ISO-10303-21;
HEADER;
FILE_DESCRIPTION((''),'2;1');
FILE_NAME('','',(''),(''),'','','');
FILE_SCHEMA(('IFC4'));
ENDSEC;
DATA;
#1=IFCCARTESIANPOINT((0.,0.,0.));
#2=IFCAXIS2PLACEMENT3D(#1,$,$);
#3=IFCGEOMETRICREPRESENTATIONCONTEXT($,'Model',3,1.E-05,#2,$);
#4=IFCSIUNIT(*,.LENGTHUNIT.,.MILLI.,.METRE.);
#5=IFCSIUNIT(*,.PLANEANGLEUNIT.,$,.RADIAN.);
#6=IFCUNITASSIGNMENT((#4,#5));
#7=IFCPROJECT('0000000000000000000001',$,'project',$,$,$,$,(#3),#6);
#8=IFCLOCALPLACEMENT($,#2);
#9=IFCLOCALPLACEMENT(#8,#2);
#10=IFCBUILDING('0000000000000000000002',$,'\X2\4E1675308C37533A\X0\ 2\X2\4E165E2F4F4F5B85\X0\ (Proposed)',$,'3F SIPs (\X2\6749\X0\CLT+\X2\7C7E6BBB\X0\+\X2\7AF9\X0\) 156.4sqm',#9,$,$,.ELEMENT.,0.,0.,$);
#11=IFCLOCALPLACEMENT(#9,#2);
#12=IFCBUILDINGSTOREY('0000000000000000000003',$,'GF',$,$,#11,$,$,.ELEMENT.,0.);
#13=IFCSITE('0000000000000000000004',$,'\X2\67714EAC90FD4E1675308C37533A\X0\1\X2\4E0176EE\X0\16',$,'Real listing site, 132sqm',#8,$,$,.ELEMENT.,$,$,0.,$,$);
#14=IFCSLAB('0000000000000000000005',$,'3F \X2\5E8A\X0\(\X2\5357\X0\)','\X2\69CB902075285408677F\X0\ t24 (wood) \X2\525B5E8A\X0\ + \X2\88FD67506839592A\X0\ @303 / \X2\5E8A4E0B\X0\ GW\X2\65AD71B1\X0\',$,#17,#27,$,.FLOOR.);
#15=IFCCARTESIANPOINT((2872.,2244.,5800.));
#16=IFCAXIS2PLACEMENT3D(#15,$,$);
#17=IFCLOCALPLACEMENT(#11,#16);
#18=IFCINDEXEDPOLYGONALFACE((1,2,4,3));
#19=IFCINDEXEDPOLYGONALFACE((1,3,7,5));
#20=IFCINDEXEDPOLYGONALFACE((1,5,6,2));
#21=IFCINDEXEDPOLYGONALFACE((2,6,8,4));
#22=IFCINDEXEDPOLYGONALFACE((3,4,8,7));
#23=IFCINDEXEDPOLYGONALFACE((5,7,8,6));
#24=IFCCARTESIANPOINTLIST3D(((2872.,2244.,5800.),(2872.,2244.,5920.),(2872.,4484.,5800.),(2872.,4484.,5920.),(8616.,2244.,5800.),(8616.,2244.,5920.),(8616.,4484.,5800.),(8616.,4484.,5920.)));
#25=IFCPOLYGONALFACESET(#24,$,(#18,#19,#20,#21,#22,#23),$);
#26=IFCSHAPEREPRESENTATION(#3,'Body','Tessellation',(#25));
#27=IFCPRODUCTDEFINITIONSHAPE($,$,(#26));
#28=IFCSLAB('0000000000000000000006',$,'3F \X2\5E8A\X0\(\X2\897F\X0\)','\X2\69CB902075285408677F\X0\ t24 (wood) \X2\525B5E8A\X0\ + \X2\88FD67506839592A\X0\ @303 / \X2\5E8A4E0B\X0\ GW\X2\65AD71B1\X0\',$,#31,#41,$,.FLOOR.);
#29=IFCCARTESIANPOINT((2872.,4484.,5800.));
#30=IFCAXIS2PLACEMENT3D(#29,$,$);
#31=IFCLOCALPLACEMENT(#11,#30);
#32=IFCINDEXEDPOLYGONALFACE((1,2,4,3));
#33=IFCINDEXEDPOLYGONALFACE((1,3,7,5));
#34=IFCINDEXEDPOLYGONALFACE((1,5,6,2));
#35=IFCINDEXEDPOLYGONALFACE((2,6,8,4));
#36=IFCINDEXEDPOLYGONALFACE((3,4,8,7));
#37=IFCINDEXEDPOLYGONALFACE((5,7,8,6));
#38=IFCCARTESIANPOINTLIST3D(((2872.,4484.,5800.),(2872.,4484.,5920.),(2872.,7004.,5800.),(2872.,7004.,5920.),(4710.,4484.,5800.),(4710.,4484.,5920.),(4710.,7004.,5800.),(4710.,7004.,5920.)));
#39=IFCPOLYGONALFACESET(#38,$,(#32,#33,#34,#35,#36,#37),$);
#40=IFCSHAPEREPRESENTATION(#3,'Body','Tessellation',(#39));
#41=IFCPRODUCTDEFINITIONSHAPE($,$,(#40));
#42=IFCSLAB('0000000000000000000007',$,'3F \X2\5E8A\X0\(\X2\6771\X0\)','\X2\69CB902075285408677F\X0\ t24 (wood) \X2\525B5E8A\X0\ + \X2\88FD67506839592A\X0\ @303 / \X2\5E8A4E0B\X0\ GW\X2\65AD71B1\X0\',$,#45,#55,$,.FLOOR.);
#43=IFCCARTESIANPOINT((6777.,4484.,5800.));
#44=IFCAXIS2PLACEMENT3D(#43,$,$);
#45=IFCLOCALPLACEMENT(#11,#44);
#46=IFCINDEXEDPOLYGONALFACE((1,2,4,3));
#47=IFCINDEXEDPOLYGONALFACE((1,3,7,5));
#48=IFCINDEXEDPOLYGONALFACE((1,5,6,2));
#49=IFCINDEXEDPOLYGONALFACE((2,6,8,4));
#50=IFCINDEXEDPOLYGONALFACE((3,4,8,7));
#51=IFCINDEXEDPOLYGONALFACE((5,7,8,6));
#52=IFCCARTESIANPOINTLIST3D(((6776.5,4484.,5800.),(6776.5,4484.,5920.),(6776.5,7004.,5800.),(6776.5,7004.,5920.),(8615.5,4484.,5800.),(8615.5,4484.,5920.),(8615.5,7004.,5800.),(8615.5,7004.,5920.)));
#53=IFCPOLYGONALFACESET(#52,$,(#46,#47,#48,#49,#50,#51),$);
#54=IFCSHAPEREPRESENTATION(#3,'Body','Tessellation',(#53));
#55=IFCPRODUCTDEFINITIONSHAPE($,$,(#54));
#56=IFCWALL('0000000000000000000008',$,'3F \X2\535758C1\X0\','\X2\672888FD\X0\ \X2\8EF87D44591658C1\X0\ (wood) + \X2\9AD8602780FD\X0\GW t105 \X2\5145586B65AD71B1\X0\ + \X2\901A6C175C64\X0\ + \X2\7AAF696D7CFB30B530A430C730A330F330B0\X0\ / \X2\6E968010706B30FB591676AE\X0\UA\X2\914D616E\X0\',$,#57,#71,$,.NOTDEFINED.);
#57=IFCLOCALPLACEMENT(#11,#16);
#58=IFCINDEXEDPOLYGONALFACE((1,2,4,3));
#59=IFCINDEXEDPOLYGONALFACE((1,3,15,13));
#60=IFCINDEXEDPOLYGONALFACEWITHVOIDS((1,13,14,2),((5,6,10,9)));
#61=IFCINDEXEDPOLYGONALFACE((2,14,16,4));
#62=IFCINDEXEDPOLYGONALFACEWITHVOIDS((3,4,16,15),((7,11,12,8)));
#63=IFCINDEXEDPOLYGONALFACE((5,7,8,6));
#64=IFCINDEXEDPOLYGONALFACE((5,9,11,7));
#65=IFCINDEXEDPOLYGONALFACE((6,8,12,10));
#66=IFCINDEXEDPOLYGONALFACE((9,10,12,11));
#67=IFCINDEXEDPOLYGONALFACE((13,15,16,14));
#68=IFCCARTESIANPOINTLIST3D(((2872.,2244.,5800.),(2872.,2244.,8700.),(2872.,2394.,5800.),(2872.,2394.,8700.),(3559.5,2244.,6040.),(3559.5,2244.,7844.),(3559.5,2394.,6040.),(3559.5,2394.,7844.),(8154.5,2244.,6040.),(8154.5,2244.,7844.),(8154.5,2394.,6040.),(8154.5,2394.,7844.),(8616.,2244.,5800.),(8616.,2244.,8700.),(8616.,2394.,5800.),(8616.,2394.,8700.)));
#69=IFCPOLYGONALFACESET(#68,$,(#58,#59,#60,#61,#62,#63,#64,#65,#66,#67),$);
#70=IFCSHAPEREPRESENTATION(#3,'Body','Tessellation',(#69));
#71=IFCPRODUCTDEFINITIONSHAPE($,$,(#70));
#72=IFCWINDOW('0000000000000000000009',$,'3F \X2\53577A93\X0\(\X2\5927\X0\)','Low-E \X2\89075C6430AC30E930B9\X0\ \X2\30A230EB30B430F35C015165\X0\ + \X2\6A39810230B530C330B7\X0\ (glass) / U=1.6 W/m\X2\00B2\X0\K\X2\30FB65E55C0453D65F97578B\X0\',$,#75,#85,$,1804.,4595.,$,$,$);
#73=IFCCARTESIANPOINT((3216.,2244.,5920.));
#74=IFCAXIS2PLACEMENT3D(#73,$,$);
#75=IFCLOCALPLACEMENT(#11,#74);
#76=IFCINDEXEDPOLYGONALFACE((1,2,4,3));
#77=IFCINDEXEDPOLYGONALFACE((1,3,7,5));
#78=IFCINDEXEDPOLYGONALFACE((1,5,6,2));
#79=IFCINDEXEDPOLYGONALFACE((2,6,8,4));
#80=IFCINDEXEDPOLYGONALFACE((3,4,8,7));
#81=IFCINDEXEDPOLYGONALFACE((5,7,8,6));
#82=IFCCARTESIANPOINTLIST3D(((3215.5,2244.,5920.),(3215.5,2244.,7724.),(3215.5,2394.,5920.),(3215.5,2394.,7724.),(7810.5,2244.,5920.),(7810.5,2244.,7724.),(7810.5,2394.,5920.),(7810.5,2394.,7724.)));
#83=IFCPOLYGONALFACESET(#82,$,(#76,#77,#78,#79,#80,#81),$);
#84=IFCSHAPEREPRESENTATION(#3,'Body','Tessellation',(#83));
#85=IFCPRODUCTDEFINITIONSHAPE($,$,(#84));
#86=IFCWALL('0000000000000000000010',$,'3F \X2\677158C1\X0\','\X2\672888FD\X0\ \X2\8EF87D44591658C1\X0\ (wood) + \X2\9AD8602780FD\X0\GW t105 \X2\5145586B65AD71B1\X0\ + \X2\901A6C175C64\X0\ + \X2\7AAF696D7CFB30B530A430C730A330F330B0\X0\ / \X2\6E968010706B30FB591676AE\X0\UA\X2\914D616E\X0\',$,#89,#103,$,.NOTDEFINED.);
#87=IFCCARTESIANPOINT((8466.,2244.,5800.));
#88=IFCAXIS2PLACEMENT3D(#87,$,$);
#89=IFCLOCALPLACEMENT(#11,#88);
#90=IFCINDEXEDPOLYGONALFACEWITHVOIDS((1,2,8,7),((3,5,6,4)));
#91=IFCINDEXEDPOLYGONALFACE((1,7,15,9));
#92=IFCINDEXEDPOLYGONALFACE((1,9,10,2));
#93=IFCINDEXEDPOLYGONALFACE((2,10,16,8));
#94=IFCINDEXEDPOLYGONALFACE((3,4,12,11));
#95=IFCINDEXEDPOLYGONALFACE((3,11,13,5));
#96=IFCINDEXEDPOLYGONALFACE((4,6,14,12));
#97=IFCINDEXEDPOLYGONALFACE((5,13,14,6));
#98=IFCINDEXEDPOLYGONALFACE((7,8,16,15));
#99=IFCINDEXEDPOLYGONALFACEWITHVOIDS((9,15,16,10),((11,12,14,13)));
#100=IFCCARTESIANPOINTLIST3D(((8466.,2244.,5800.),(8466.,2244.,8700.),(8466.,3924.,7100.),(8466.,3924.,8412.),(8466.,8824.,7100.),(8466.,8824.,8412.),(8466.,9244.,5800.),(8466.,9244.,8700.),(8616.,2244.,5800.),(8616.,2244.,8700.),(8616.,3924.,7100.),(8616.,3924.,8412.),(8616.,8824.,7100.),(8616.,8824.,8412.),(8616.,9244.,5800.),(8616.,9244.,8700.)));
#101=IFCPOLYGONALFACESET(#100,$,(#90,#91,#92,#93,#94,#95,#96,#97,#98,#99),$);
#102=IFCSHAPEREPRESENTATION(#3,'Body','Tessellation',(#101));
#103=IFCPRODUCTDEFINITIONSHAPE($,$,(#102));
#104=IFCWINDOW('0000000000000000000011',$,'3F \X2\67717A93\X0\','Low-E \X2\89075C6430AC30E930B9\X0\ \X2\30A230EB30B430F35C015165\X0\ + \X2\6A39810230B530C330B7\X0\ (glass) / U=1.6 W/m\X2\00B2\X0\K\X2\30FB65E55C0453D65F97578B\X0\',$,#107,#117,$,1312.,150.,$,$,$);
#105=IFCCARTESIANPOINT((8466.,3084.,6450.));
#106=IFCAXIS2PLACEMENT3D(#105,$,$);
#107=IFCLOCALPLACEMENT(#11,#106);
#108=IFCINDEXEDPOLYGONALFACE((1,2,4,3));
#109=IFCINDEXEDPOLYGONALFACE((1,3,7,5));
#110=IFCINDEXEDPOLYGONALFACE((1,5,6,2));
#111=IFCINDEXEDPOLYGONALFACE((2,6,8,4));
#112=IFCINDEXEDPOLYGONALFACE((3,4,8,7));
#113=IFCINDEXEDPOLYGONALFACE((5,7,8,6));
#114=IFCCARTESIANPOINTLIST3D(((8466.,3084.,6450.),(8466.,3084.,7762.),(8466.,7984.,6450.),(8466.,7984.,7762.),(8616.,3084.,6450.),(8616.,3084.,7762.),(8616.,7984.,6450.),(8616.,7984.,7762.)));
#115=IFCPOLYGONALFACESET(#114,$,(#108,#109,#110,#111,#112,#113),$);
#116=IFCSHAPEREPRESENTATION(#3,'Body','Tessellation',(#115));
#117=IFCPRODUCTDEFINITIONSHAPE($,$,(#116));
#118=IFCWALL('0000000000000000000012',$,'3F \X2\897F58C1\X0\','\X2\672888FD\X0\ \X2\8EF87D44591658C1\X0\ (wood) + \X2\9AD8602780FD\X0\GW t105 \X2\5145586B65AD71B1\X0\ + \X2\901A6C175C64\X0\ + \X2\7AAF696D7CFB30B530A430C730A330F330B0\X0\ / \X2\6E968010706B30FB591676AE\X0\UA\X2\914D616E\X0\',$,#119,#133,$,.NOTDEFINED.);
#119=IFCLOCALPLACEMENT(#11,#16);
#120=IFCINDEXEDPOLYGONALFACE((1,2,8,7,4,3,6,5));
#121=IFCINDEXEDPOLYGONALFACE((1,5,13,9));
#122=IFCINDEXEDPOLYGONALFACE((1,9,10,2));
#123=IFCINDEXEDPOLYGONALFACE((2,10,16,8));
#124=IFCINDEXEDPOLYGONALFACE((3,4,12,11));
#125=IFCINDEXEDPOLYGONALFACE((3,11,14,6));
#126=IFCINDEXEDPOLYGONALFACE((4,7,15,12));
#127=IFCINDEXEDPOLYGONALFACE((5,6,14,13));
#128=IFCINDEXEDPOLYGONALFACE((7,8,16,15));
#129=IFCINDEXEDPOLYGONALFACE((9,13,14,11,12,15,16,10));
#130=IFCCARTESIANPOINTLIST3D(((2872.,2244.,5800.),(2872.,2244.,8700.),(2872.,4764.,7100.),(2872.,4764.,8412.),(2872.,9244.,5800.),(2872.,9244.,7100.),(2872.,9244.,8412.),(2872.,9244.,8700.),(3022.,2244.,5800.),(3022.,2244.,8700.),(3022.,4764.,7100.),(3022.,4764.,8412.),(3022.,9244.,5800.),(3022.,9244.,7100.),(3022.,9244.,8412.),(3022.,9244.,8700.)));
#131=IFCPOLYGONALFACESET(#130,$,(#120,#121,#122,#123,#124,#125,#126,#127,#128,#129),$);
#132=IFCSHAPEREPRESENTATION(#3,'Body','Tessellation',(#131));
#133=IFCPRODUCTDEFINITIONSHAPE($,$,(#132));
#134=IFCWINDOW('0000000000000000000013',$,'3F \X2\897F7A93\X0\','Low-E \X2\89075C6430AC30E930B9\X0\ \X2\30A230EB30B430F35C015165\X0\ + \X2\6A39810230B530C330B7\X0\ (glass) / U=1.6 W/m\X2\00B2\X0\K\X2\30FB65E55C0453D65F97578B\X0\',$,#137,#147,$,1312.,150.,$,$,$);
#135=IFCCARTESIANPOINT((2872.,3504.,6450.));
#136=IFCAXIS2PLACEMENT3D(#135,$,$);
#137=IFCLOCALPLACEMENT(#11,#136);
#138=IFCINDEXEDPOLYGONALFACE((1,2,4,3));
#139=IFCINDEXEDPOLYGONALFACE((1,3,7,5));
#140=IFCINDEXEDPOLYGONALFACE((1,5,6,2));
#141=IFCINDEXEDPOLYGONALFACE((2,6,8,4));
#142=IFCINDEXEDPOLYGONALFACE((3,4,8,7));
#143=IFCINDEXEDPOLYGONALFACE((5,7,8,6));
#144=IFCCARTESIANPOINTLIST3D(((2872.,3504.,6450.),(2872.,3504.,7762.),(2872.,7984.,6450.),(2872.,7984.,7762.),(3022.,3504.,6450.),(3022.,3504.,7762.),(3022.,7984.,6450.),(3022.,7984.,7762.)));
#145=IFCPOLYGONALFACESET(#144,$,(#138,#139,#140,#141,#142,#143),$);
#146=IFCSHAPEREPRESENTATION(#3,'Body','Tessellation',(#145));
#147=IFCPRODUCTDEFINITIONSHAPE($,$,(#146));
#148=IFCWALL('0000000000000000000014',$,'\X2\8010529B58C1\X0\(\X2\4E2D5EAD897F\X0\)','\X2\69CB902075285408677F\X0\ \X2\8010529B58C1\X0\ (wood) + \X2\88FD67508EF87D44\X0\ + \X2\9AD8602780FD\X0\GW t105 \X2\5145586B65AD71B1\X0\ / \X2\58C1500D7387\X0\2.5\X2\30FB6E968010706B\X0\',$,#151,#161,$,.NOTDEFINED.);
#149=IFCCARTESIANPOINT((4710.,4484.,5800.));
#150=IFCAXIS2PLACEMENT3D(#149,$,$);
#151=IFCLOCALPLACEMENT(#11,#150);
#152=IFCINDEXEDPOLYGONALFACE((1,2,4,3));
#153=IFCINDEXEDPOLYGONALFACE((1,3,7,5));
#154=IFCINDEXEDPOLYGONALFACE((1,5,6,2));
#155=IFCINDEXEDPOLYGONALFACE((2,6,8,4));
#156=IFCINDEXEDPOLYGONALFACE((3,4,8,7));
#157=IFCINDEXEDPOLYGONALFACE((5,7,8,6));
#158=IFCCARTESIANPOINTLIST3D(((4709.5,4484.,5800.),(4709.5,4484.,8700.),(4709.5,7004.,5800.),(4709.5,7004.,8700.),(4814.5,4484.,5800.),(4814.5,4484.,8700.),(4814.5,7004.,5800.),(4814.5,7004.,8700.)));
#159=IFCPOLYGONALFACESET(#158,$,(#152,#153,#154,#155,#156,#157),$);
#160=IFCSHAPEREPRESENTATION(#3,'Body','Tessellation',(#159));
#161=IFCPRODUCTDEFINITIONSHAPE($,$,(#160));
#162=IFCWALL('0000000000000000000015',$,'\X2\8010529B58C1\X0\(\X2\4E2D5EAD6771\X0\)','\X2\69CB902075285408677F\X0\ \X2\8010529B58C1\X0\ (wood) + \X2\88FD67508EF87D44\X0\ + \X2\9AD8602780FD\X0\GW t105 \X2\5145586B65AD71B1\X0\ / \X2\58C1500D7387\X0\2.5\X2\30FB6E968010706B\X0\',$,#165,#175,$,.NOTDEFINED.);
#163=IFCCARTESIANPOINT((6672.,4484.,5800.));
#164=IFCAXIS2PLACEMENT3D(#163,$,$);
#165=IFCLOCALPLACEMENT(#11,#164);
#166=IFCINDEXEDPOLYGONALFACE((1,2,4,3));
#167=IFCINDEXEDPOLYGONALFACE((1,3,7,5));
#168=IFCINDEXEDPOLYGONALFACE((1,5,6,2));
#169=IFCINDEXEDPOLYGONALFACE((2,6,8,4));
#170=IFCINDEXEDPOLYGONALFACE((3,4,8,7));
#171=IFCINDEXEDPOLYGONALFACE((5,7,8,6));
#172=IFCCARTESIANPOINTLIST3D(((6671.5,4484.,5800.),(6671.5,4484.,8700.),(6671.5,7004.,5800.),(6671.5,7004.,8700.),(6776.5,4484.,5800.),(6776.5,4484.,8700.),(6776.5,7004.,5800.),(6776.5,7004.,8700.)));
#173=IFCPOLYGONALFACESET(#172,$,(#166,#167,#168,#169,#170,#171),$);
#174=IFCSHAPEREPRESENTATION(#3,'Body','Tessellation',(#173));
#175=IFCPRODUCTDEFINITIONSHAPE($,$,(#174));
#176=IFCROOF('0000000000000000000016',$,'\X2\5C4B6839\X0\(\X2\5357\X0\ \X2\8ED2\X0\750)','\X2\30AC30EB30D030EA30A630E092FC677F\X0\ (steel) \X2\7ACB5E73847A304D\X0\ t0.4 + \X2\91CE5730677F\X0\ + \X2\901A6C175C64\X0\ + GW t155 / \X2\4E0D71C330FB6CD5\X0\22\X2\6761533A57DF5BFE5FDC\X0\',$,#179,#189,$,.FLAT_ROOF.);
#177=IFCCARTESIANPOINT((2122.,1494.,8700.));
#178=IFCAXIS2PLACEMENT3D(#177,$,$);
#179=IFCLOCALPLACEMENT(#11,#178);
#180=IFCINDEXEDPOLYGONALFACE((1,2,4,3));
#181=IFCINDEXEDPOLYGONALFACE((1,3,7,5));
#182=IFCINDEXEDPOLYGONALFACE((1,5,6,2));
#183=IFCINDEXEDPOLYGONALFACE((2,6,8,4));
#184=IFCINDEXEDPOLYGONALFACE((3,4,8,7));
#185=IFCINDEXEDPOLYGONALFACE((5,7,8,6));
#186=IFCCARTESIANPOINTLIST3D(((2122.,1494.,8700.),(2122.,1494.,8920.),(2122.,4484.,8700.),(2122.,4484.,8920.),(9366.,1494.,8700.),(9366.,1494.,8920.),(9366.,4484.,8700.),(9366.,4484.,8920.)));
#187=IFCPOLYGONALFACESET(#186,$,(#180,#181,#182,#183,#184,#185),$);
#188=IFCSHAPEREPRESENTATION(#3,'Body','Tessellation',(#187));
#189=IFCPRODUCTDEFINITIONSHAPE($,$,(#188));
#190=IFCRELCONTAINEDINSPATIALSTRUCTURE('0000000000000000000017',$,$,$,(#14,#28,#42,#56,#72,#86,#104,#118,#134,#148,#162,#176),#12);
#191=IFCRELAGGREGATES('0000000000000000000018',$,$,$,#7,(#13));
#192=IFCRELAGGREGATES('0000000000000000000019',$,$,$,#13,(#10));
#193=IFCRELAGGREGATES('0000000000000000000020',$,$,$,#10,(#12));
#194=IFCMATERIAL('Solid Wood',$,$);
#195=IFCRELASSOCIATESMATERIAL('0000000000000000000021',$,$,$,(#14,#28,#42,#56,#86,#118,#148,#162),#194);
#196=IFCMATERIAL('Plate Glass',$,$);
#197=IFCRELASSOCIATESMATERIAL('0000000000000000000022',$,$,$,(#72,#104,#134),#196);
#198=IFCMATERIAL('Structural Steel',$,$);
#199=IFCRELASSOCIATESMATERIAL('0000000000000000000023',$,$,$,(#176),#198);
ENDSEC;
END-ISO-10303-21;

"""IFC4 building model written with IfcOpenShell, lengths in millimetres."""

from ifc_helpers import new_model, si_unit, frame, frame_2d, origin, place, context, project, spatial, rectangle, extrude, material, element, fill, save


model = new_model("IFC4")

# Units and contexts
model_context = context("Model", 3, precision=1e-05, world=origin())
ifc_project = project(units=[si_unit("LENGTHUNIT", "METRE", prefix="MILLI"), si_unit("PLANEANGLEUNIT", "RADIAN")], contexts=[model_context])

# Site, building, storey
site_placement = place(None, origin())
site = spatial("IfcSite", under=ifc_project, at=site_placement, Name="東京都世田谷区1丁目16", ObjectType="Real listing site, 132sqm", CompositionType="ELEMENT", RefElevation=0.0)
building_placement = place(site_placement, origin())
building = spatial("IfcBuilding", under=site, at=building_placement, Name="世田谷区 2世帯住宅 (Proposed)", ObjectType="3F SIPs (杉CLT+籾殻+竹) 156.4sqm", CompositionType="ELEMENT", ElevationOfRefHeight=0.0, ElevationOfTerrain=0.0)
storey_placement = place(building_placement, origin())
storey = spatial("IfcBuildingStorey", under=building, at=storey_placement, Name="GF", CompositionType="ELEMENT", Elevation=0.0)

# Slabs
ifc_material_1 = material(Name="Solid Wood")
slab_1_placement = place(storey_placement, frame((2872.0, 2244.0, 5800.0)))
element("IfcSlab", 1, at=slab_1_placement, inside=storey, material=ifc_material_1, Name="3F 床(南)", Description="構造用合板 t24 (wood) 剛床 + 製材根太 @303 / 床下 GW断熱", PredefinedType="FLOOR", context=model_context, shape_type="SweptSolid", body=[
    extrude(rectangle(XDim=5744.0, YDim=2240.0, at=frame_2d((2872.0, 1120.0))), frame((2872.0, 2244.0, 5800.0)), (0.0, 0.0, 1.0), 120.0),
])
slab_2_placement = place(storey_placement, frame((2872.0, 4484.0, 5800.0)))
element("IfcSlab", 2, at=slab_2_placement, inside=storey, material=ifc_material_1, Name="3F 床(西)", Description="構造用合板 t24 (wood) 剛床 + 製材根太 @303 / 床下 GW断熱", PredefinedType="FLOOR", context=model_context, shape_type="SweptSolid", body=[
    extrude(rectangle(XDim=1838.0, YDim=2520.0, at=frame_2d((919.0, 1260.0))), frame((2872.0, 4484.0, 5800.0)), (0.0, 0.0, 1.0), 120.0),
])
slab_3_placement = place(storey_placement, frame((6777.0, 4484.0, 5800.0)))
element("IfcSlab", 3, at=slab_3_placement, inside=storey, material=ifc_material_1, Name="3F 床(東)", Description="構造用合板 t24 (wood) 剛床 + 製材根太 @303 / 床下 GW断熱", PredefinedType="FLOOR", context=model_context, shape_type="SweptSolid", body=[
    extrude(rectangle(XDim=1839.0, YDim=2520.0, at=frame_2d((919.0, 1260.0))), frame((6777.0, 4484.0, 5800.0)), (0.0, 0.0, 1.0), 120.0),
])

# Walls, openings, windows
wall_1_placement = place(storey_placement, frame((2872.0, 2244.0, 5800.0)))
wall_1 = element("IfcWall", 4, at=wall_1_placement, inside=storey, material=ifc_material_1, Name="3F 南壁", Description="木製 軸組外壁 (wood) + 高性能GW t105 充填断熱 + 通気層 + 窯業系サイディング / 準耐火・外皮UA配慮", PredefinedType="NOTDEFINED", context=model_context, shape_type="SweptSolid", body=[
    extrude(rectangle(XDim=5744.0, YDim=150.0, at=frame_2d((2872.0, 75.0))), frame((2872.0, 2244.0, 5800.0)), (0.0, 0.0, 1.0), 2900.0),
])
opening_1_placement = place(storey_placement, frame((3216.0, 2244.0, 5920.0)))
opening_1 = element("IfcOpeningElement", 5, at=opening_1_placement, cuts=wall_1, PredefinedType="NOTDEFINED", context=model_context, shape_type="SweptSolid", body=[
    extrude(rectangle(XDim=4595.0, YDim=150.0, at=frame_2d((2297.0, 75.0))), frame((3216.0, 2244.0, 5920.0)), (0.0, 0.0, 1.0), 1804.0),
])
ifc_material_2 = material(Name="Plate Glass")
window_1_placement = place(storey_placement, frame((3216.0, 2244.0, 5920.0)))
window_1 = element("IfcWindow", 6, at=window_1_placement, inside=storey, material=ifc_material_2, Name="3F 南窓(大)", Description="Low-E 複層ガラス アルゴン封入 + 樹脂サッシ (glass) / U=1.6 W/m²K・日射取得型", OverallHeight=1804.0, OverallWidth=4595.0, context=model_context, shape_type="SweptSolid", body=[
    extrude(rectangle(XDim=4595.0, YDim=150.0, at=frame_2d((2297.0, 75.0))), frame((3216.0, 2244.0, 5920.0)), (0.0, 0.0, 1.0), 1804.0),
])
fill(opening_1, window_1)
wall_2_placement = place(storey_placement, frame((8466.0, 2244.0, 5800.0)))
wall_2 = element("IfcWall", 7, at=wall_2_placement, inside=storey, material=ifc_material_1, Name="3F 東壁", Description="木製 軸組外壁 (wood) + 高性能GW t105 充填断熱 + 通気層 + 窯業系サイディング / 準耐火・外皮UA配慮", PredefinedType="NOTDEFINED", context=model_context, shape_type="SweptSolid", body=[
    extrude(rectangle(XDim=150.0, YDim=7000.0, at=frame_2d((75.0, 3500.0))), frame((8466.0, 2244.0, 5800.0)), (0.0, 0.0, 1.0), 2900.0),
])
opening_2_placement = place(storey_placement, frame((8466.0, 3084.0, 6450.0)))
opening_2 = element("IfcOpeningElement", 8, at=opening_2_placement, cuts=wall_2, PredefinedType="NOTDEFINED", context=model_context, shape_type="SweptSolid", body=[
    extrude(rectangle(XDim=150.0, YDim=4900.0, at=frame_2d((75.0, 2450.0))), frame((8466.0, 3084.0, 6450.0)), (0.0, 0.0, 1.0), 1312.0),
])
window_2_placement = place(storey_placement, frame((8466.0, 3084.0, 6450.0)))
window_2 = element("IfcWindow", 9, at=window_2_placement, inside=storey, material=ifc_material_2, Name="3F 東窓", Description="Low-E 複層ガラス アルゴン封入 + 樹脂サッシ (glass) / U=1.6 W/m²K・日射取得型", OverallHeight=1312.0, OverallWidth=150.0, context=model_context, shape_type="SweptSolid", body=[
    extrude(rectangle(XDim=150.0, YDim=4900.0, at=frame_2d((75.0, 2450.0))), frame((8466.0, 3084.0, 6450.0)), (0.0, 0.0, 1.0), 1312.0),
])
fill(opening_2, window_2)
wall_3_placement = place(storey_placement, frame((2872.0, 2244.0, 5800.0)))
wall_3 = element("IfcWall", 10, at=wall_3_placement, inside=storey, material=ifc_material_1, Name="3F 西壁", Description="木製 軸組外壁 (wood) + 高性能GW t105 充填断熱 + 通気層 + 窯業系サイディング / 準耐火・外皮UA配慮", PredefinedType="NOTDEFINED", context=model_context, shape_type="SweptSolid", body=[
    extrude(rectangle(XDim=150.0, YDim=7000.0, at=frame_2d((75.0, 3500.0))), frame((2872.0, 2244.0, 5800.0)), (0.0, 0.0, 1.0), 2900.0),
])
opening_3_placement = place(storey_placement, frame((2872.0, 3504.0, 6450.0)))
opening_3 = element("IfcOpeningElement", 11, at=opening_3_placement, cuts=wall_3, PredefinedType="NOTDEFINED", context=model_context, shape_type="SweptSolid", body=[
    extrude(rectangle(XDim=150.0, YDim=4480.0, at=frame_2d((75.0, 2240.0))), frame((2872.0, 3504.0, 6450.0)), (0.0, 0.0, 1.0), 1312.0),
])
window_3_placement = place(storey_placement, frame((2872.0, 3504.0, 6450.0)))
window_3 = element("IfcWindow", 12, at=window_3_placement, inside=storey, material=ifc_material_2, Name="3F 西窓", Description="Low-E 複層ガラス アルゴン封入 + 樹脂サッシ (glass) / U=1.6 W/m²K・日射取得型", OverallHeight=1312.0, OverallWidth=150.0, context=model_context, shape_type="SweptSolid", body=[
    extrude(rectangle(XDim=150.0, YDim=4480.0, at=frame_2d((75.0, 2240.0))), frame((2872.0, 3504.0, 6450.0)), (0.0, 0.0, 1.0), 1312.0),
])
fill(opening_3, window_3)

# Walls
wall_4_placement = place(storey_placement, frame((4710.0, 4484.0, 5800.0)))
element("IfcWall", 13, at=wall_4_placement, inside=storey, material=ifc_material_1, Name="耐力壁(中庭西)", Description="構造用合板 耐力壁 (wood) + 製材軸組 + 高性能GW t105 充填断熱 / 壁倍率2.5・準耐火", PredefinedType="NOTDEFINED", context=model_context, shape_type="SweptSolid", body=[
    extrude(rectangle(XDim=105.0, YDim=2520.0, at=frame_2d((52.0, 1260.0))), frame((4710.0, 4484.0, 5800.0)), (0.0, 0.0, 1.0), 2900.0),
])
wall_5_placement = place(storey_placement, frame((6672.0, 4484.0, 5800.0)))
element("IfcWall", 14, at=wall_5_placement, inside=storey, material=ifc_material_1, Name="耐力壁(中庭東)", Description="構造用合板 耐力壁 (wood) + 製材軸組 + 高性能GW t105 充填断熱 / 壁倍率2.5・準耐火", PredefinedType="NOTDEFINED", context=model_context, shape_type="SweptSolid", body=[
    extrude(rectangle(XDim=105.0, YDim=2520.0, at=frame_2d((52.0, 1260.0))), frame((6672.0, 4484.0, 5800.0)), (0.0, 0.0, 1.0), 2900.0),
])

# Roof
ifc_material_3 = material(Name="Structural Steel")
roof_1_placement = place(storey_placement, frame((2122.0, 1494.0, 8700.0)))
element("IfcRoof", 15, at=roof_1_placement, inside=storey, material=ifc_material_3, Name="屋根(南 軒750)", Description="ガルバリウム鋼板 (steel) 立平葺き t0.4 + 野地板 + 通気層 + GW t155 / 不燃・法22条区域対応", PredefinedType="FLAT_ROOF", context=model_context, shape_type="SweptSolid", body=[
    extrude(rectangle(XDim=7244.0, YDim=2990.0, at=frame_2d((3622.0, 1495.0))), frame((2122.0, 1494.0, 8700.0)), (0.0, 0.0, 1.0), 220.0),
])

save(model, "model.ifc")
